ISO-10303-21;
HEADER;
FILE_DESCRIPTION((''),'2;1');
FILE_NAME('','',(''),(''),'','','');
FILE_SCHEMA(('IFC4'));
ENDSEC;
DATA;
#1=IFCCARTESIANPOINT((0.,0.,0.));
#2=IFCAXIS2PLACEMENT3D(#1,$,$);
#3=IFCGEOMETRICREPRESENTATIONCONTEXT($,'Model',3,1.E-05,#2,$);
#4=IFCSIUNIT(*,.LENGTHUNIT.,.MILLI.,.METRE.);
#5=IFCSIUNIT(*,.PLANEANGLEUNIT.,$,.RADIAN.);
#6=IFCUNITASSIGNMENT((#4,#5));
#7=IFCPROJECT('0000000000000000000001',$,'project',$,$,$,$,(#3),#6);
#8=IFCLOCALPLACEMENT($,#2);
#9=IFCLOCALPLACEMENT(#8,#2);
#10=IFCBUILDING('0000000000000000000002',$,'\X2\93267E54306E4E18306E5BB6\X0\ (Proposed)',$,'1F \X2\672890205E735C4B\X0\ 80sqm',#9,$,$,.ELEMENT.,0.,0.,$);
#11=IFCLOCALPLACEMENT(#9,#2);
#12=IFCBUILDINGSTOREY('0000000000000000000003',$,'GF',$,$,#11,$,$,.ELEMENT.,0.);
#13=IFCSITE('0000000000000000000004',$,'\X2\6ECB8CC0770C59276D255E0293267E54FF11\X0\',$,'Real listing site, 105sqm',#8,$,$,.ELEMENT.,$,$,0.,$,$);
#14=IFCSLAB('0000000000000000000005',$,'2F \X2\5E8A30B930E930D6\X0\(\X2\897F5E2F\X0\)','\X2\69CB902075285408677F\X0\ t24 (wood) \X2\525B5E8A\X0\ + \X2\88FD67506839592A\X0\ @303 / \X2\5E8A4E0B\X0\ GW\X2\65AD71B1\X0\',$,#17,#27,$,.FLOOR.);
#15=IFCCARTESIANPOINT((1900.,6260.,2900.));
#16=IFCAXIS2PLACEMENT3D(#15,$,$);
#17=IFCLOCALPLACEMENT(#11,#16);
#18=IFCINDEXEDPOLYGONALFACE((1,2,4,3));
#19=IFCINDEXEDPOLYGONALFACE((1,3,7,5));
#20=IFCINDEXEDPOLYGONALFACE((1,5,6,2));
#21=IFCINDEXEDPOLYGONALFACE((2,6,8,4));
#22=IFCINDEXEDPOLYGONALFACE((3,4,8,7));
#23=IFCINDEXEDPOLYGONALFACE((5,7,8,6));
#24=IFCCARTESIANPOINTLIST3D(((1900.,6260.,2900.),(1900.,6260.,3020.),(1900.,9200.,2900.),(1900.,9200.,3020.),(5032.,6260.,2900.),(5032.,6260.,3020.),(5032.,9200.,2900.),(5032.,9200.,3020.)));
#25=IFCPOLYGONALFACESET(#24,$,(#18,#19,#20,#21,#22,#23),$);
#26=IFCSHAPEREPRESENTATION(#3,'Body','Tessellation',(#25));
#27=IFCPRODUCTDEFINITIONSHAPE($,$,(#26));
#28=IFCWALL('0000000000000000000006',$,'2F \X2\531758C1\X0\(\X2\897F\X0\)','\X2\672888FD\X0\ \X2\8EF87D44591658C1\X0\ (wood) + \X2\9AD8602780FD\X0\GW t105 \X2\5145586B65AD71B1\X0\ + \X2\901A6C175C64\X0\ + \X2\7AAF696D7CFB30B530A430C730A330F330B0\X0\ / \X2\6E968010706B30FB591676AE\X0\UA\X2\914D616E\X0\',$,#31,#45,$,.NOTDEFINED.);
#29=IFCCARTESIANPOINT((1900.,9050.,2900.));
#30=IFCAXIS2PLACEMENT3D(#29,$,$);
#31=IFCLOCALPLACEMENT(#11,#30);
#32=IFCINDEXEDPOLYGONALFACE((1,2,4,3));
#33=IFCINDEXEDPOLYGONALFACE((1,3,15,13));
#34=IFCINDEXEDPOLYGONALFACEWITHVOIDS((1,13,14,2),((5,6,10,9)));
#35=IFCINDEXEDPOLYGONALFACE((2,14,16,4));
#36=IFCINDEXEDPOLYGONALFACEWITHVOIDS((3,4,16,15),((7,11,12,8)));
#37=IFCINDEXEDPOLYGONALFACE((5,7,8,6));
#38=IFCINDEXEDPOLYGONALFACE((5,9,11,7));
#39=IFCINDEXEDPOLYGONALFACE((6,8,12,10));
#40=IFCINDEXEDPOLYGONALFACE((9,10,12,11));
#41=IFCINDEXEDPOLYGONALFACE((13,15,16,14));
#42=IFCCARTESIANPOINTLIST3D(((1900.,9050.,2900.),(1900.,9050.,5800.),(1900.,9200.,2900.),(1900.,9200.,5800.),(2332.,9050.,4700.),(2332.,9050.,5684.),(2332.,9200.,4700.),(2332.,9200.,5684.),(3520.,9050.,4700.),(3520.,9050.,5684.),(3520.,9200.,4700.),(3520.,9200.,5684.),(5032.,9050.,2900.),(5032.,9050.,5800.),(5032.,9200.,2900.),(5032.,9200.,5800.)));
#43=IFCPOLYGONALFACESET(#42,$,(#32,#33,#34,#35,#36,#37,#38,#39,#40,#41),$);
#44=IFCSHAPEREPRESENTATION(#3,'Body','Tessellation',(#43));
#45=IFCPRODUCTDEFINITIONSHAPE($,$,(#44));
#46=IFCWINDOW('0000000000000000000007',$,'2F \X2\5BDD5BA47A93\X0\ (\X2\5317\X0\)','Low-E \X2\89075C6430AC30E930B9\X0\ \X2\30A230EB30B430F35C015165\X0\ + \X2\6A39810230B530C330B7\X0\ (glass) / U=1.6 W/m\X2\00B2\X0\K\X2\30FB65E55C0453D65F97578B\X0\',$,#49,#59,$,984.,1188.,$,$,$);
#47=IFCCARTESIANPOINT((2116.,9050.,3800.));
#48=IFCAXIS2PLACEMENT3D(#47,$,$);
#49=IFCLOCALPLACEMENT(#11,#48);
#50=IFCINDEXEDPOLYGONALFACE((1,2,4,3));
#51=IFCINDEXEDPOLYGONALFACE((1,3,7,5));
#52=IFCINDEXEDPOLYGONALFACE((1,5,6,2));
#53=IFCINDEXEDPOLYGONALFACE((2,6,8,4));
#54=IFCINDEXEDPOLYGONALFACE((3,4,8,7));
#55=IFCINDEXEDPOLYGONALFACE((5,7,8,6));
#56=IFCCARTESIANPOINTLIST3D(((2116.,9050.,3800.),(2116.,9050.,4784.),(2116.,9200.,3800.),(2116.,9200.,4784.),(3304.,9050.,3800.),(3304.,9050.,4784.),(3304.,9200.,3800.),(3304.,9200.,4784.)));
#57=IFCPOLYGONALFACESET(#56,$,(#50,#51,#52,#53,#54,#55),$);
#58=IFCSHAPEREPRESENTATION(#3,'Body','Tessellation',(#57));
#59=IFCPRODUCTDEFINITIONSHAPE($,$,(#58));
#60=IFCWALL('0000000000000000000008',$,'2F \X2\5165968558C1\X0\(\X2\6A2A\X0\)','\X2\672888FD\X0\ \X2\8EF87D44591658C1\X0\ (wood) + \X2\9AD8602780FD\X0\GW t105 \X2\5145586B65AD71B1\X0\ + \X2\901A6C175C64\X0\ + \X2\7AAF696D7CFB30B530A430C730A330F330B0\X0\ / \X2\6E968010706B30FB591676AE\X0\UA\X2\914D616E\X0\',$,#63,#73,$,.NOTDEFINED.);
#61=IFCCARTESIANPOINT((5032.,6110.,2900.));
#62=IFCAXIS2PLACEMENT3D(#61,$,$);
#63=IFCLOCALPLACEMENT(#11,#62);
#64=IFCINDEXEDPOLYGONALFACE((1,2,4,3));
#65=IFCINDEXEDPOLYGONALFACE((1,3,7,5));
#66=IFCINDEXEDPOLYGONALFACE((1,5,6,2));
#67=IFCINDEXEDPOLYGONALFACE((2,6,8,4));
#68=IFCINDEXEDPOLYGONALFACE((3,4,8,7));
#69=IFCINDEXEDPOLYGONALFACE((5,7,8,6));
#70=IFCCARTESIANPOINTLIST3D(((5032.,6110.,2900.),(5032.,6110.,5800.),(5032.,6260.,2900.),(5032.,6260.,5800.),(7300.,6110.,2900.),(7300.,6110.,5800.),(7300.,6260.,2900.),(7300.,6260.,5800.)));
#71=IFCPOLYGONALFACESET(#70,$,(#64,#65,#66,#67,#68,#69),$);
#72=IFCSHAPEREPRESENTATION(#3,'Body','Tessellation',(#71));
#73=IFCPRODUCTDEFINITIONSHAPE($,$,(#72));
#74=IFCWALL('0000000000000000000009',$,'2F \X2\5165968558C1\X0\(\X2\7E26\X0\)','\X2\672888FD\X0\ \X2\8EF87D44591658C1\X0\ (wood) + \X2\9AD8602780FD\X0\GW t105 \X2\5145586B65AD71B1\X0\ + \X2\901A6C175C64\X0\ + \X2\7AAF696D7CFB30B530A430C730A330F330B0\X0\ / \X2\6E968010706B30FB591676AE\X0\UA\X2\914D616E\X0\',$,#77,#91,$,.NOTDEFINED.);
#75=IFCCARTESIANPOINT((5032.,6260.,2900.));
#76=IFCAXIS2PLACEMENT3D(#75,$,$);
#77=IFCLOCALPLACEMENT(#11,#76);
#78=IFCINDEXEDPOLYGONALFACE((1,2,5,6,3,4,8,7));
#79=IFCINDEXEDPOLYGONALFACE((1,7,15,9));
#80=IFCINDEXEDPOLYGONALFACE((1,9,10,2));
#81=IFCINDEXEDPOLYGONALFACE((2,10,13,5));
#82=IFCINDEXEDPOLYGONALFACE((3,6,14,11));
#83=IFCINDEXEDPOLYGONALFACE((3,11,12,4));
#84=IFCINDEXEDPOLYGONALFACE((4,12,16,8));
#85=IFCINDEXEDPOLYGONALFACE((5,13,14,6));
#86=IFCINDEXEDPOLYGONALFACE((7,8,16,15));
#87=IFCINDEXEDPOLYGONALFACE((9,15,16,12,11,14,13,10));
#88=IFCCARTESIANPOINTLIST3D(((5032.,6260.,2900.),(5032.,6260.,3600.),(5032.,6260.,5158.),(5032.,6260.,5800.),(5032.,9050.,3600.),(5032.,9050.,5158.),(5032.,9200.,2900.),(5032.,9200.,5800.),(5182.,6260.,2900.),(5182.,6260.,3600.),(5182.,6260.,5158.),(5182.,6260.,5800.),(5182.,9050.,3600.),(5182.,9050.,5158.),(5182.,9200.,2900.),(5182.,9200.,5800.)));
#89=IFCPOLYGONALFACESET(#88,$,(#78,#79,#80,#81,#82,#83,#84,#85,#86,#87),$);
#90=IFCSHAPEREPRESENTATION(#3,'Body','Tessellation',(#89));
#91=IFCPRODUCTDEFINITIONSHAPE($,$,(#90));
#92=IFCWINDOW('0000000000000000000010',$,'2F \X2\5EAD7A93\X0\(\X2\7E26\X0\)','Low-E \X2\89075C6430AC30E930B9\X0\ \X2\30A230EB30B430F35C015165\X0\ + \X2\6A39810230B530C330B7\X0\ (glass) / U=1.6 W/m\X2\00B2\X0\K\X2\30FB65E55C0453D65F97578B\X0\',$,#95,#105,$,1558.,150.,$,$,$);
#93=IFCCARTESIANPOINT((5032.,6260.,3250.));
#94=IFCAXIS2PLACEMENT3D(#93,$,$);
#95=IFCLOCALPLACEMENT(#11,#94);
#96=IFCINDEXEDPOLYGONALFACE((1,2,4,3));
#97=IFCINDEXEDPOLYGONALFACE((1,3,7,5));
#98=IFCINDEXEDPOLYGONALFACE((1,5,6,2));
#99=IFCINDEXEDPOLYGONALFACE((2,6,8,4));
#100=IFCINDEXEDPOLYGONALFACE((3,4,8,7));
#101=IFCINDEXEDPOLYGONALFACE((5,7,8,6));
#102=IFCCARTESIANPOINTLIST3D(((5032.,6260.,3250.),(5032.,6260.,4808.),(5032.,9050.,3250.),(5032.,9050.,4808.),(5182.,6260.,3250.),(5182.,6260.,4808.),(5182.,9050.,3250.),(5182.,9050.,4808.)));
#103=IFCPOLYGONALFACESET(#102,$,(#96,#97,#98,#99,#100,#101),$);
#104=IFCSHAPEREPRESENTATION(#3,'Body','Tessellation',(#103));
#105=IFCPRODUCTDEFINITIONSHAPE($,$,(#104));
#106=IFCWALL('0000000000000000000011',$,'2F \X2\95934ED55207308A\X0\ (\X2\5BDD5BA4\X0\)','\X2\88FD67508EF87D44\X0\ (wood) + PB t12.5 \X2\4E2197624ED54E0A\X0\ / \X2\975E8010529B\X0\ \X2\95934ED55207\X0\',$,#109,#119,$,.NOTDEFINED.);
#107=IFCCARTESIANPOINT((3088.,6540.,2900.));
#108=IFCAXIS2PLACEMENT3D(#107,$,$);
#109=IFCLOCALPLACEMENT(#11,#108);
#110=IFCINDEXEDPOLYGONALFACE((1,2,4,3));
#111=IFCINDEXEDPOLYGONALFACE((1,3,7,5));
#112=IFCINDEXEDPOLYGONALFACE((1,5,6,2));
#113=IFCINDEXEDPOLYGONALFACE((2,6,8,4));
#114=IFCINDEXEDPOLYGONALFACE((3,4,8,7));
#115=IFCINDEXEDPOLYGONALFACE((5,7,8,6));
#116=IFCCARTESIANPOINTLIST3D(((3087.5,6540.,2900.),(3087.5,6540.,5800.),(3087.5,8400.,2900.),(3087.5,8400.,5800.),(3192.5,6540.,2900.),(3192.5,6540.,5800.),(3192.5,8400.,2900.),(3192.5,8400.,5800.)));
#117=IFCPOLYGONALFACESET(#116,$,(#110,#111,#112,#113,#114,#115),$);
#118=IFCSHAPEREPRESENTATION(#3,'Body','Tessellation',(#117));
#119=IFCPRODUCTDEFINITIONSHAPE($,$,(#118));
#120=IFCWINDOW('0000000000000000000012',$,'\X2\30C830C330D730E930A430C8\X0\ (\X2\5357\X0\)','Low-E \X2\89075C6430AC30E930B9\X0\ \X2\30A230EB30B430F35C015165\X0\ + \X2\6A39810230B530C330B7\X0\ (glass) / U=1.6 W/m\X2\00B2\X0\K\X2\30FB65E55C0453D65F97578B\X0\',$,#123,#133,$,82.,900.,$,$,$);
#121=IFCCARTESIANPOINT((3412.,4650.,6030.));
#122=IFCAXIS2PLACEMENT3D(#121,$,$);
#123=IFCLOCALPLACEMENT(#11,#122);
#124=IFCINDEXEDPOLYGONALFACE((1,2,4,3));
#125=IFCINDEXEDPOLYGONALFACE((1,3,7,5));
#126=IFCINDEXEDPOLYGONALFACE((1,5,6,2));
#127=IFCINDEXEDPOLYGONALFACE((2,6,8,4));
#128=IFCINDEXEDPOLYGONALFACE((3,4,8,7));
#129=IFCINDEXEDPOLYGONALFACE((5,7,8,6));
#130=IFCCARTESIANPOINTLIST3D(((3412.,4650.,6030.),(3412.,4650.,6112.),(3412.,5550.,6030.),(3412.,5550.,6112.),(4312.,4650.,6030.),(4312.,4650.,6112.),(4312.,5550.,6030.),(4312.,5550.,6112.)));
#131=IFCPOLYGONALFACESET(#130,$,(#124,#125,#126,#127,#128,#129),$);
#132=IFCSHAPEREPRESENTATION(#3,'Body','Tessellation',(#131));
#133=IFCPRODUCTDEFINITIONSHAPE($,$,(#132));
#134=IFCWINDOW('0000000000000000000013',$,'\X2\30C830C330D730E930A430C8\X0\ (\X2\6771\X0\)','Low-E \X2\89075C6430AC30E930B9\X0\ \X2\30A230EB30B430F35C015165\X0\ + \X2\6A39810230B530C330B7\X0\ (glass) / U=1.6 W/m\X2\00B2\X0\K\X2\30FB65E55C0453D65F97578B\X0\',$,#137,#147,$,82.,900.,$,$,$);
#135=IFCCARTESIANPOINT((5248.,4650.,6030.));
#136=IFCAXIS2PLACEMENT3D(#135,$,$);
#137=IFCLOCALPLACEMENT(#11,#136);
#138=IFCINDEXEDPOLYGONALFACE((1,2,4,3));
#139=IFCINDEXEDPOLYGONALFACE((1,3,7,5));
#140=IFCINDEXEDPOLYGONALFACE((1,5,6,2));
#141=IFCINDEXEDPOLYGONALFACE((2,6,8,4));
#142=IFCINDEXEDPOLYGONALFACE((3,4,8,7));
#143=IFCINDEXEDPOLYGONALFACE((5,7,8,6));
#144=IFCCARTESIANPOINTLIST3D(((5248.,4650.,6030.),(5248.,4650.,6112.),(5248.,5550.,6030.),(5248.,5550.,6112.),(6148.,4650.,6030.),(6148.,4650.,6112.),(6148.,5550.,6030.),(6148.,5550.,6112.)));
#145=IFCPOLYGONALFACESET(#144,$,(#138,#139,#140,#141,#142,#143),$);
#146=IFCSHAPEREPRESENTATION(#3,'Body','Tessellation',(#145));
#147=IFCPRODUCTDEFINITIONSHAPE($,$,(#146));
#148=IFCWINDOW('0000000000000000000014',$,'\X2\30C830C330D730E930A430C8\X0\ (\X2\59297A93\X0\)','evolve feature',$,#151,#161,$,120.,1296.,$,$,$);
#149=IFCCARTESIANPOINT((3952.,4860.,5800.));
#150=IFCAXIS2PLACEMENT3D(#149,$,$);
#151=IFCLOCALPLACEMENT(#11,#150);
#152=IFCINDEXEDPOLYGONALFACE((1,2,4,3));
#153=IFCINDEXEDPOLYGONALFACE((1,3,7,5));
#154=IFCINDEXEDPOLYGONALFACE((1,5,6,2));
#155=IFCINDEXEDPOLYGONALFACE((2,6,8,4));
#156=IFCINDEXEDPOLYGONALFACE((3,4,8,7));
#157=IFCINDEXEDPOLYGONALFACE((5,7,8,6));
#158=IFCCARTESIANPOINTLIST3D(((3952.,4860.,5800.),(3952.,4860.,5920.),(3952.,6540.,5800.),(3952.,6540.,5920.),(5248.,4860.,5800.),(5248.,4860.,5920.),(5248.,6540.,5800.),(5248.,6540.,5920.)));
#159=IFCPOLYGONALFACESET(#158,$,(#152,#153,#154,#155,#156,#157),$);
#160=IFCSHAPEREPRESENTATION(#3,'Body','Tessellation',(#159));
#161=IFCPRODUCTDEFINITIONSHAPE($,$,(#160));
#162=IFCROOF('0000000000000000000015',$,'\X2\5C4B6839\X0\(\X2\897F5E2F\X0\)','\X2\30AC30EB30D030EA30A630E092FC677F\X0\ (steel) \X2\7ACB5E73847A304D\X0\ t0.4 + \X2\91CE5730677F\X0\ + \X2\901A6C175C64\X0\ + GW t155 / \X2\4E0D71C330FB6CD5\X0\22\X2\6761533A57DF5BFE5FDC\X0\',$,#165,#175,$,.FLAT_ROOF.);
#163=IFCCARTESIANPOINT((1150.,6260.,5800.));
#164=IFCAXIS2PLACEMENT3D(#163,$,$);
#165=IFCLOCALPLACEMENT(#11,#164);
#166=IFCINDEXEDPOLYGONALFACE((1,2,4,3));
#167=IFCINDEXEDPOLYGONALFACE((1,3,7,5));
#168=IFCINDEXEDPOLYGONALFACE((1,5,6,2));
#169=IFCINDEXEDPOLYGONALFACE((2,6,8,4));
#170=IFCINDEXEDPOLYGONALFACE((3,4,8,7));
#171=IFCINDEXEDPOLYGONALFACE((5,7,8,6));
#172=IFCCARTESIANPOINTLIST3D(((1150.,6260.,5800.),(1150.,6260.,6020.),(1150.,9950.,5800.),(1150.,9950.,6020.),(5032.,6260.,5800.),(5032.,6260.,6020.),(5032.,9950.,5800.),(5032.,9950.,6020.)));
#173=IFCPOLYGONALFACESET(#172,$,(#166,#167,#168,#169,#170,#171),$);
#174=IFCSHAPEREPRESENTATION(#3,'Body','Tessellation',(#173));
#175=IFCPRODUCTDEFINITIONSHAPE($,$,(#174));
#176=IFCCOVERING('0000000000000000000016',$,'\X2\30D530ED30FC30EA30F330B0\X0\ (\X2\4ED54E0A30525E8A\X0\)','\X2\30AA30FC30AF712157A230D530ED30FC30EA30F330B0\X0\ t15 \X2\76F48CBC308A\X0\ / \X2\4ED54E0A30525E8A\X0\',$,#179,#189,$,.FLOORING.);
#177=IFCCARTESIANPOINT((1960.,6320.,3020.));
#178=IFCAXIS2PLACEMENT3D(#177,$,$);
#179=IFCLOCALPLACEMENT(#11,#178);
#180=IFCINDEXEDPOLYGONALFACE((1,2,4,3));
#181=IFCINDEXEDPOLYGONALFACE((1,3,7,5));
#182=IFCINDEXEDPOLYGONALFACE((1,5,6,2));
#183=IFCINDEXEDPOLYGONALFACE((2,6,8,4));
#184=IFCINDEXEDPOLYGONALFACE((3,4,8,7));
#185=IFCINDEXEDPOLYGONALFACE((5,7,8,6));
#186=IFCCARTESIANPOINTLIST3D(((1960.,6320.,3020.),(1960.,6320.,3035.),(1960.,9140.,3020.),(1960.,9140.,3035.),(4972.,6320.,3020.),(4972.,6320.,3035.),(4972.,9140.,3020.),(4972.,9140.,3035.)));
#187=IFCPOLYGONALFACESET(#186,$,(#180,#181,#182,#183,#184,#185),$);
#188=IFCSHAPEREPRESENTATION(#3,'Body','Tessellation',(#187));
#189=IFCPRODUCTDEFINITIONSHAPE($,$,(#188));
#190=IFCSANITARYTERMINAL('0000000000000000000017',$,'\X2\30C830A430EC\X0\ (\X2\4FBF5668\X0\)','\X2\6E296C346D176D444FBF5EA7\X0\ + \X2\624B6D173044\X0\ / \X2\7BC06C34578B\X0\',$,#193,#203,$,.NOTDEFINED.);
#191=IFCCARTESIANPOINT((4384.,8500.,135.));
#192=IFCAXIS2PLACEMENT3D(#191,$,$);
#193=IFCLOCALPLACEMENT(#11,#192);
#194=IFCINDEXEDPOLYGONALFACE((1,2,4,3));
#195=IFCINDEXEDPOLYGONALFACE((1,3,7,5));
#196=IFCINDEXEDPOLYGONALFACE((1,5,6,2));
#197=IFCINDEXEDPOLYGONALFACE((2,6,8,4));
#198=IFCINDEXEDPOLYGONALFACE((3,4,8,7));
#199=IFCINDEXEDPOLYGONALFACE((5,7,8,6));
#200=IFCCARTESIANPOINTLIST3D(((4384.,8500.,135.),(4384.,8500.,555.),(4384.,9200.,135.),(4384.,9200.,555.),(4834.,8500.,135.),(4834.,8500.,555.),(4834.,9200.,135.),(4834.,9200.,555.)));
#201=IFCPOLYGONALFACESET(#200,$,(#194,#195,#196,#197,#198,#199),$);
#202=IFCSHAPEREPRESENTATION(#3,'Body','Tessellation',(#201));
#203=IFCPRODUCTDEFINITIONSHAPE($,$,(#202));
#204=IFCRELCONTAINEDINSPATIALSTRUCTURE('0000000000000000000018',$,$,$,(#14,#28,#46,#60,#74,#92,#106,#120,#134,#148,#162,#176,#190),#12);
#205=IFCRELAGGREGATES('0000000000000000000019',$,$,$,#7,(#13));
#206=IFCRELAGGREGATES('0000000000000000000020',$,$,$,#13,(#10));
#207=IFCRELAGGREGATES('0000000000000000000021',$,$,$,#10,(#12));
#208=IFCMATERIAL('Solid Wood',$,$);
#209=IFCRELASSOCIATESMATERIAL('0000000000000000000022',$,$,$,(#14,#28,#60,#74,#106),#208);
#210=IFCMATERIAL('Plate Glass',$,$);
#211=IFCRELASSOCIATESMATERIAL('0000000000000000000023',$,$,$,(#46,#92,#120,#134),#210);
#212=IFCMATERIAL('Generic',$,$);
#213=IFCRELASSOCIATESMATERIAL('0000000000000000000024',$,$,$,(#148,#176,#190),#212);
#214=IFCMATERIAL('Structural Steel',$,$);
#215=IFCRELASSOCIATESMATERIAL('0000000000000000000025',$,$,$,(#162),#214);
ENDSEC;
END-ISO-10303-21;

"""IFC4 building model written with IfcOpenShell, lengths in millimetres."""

from ifc_helpers import new_model, si_unit, frame, frame_2d, origin, place, context, project, spatial, rectangle, extrude, material, element, fill, save


model = new_model("IFC4")

# Units and contexts
model_context = context("Model", 3, precision=1e-05, world=origin())
ifc_project = project(units=[si_unit("LENGTHUNIT", "METRE", prefix="MILLI"), si_unit("PLANEANGLEUNIT", "RADIAN")], contexts=[model_context])

# Site, building, storey
site_placement = place(None, origin())
site = spatial("IfcSite", under=ifc_project, at=site_placement, Name="滋賀県大津市錦織１", ObjectType="Real listing site, 105sqm", CompositionType="ELEMENT", RefElevation=0.0)
building_placement = place(site_placement, origin())
building = spatial("IfcBuilding", under=site, at=building_placement, Name="錦織の丘の家 (Proposed)", ObjectType="1F 木造平屋 80sqm", CompositionType="ELEMENT", ElevationOfRefHeight=0.0, ElevationOfTerrain=0.0)
storey_placement = place(building_placement, origin())
storey = spatial("IfcBuildingStorey", under=building, at=storey_placement, Name="GF", CompositionType="ELEMENT", Elevation=0.0)

# Slab
ifc_material_1 = material(Name="Solid Wood")
slab_placement = place(storey_placement, frame((1900.0, 6260.0, 2900.0)))
element("IfcSlab", 1, at=slab_placement, inside=storey, material=ifc_material_1, Name="2F 床スラブ(西帯)", Description="構造用合板 t24 (wood) 剛床 + 製材根太 @303 / 床下 GW断熱", PredefinedType="FLOOR", context=model_context, shape_type="SweptSolid", body=[
    extrude(rectangle(XDim=3132.0, YDim=2940.0, at=frame_2d((1566.0, 1470.0))), frame((1900.0, 6260.0, 2900.0)), (0.0, 0.0, 1.0), 120.0),
])

# Wall, opening, window
wall_1_placement = place(storey_placement, frame((1900.0, 9050.0, 2900.0)))
wall_1 = element("IfcWall", 2, at=wall_1_placement, inside=storey, material=ifc_material_1, Name="2F 北壁(西)", Description="木製 軸組外壁 (wood) + 高性能GW t105 充填断熱 + 通気層 + 窯業系サイディング / 準耐火・外皮UA配慮", PredefinedType="NOTDEFINED", context=model_context, shape_type="SweptSolid", body=[
    extrude(rectangle(XDim=3132.0, YDim=150.0, at=frame_2d((1566.0, 75.0))), frame((1900.0, 9050.0, 2900.0)), (0.0, 0.0, 1.0), 2900.0),
])
opening_1_placement = place(storey_placement, frame((2116.0, 9050.0, 3800.0)))
opening_1 = element("IfcOpeningElement", 3, at=opening_1_placement, cuts=wall_1, PredefinedType="NOTDEFINED", context=model_context, shape_type="SweptSolid", body=[
    extrude(rectangle(XDim=1188.0, YDim=150.0, at=frame_2d((594.0, 75.0))), frame((2116.0, 9050.0, 3800.0)), (0.0, 0.0, 1.0), 984.0),
])
ifc_material_2 = material(Name="Plate Glass")
window_1_placement = place(storey_placement, frame((2116.0, 9050.0, 3800.0)))
window_1 = element("IfcWindow", 4, at=window_1_placement, inside=storey, material=ifc_material_2, Name="2F 寝室窓 (北)", Description="Low-E 複層ガラス アルゴン封入 + 樹脂サッシ (glass) / U=1.6 W/m²K・日射取得型", OverallHeight=984.0, OverallWidth=1188.0, context=model_context, shape_type="SweptSolid", body=[
    extrude(rectangle(XDim=1188.0, YDim=150.0, at=frame_2d((594.0, 75.0))), frame((2116.0, 9050.0, 3800.0)), (0.0, 0.0, 1.0), 984.0),
])
fill(opening_1, window_1)

# Wall
wall_2_placement = place(storey_placement, frame((5032.0, 6110.0, 2900.0)))
element("IfcWall", 5, at=wall_2_placement, inside=storey, material=ifc_material_1, Name="2F 入隅壁(横)", Description="木製 軸組外壁 (wood) + 高性能GW t105 充填断熱 + 通気層 + 窯業系サイディング / 準耐火・外皮UA配慮", PredefinedType="NOTDEFINED", context=model_context, shape_type="SweptSolid", body=[
    extrude(rectangle(XDim=2268.0, YDim=150.0, at=frame_2d((1134.0, 75.0))), frame((5032.0, 6110.0, 2900.0)), (0.0, 0.0, 1.0), 2900.0),
])

# Wall, opening, window
wall_3_placement = place(storey_placement, frame((5032.0, 6260.0, 2900.0)))
wall_3 = element("IfcWall", 6, at=wall_3_placement, inside=storey, material=ifc_material_1, Name="2F 入隅壁(縦)", Description="木製 軸組外壁 (wood) + 高性能GW t105 充填断熱 + 通気層 + 窯業系サイディング / 準耐火・外皮UA配慮", PredefinedType="NOTDEFINED", context=model_context, shape_type="SweptSolid", body=[
    extrude(rectangle(XDim=150.0, YDim=2940.0, at=frame_2d((75.0, 1470.0))), frame((5032.0, 6260.0, 2900.0)), (0.0, 0.0, 1.0), 2900.0),
])
opening_2_placement = place(storey_placement, frame((5032.0, 6260.0, 3250.0)))
opening_2 = element("IfcOpeningElement", 7, at=opening_2_placement, cuts=wall_3, PredefinedType="NOTDEFINED", context=model_context, shape_type="SweptSolid", body=[
    extrude(rectangle(XDim=150.0, YDim=2790.0, at=frame_2d((75.0, 1395.0))), frame((5032.0, 6260.0, 3250.0)), (0.0, 0.0, 1.0), 1558.0),
])
window_2_placement = place(storey_placement, frame((5032.0, 6260.0, 3250.0)))
window_2 = element("IfcWindow", 8, at=window_2_placement, inside=storey, material=ifc_material_2, Name="2F 庭窓(縦)", Description="Low-E 複層ガラス アルゴン封入 + 樹脂サッシ (glass) / U=1.6 W/m²K・日射取得型", OverallHeight=1558.0, OverallWidth=150.0, context=model_context, shape_type="SweptSolid", body=[
    extrude(rectangle(XDim=150.0, YDim=2790.0, at=frame_2d((75.0, 1395.0))), frame((5032.0, 6260.0, 3250.0)), (0.0, 0.0, 1.0), 1558.0),
])
fill(opening_2, window_2)

# Wall
wall_4_placement = place(storey_placement, frame((3088.0, 6540.0, 2900.0)))
element("IfcWall", 9, at=wall_4_placement, inside=storey, material=ifc_material_1, Name="2F 間仕切り (寝室)", Description="製材軸組 (wood) + PB t12.5 両面仕上 / 非耐力 間仕切", PredefinedType="NOTDEFINED", context=model_context, shape_type="SweptSolid", body=[
    extrude(rectangle(XDim=105.0, YDim=1860.0, at=frame_2d((52.0, 930.0))), frame((3088.0, 6540.0, 2900.0)), (0.0, 0.0, 1.0), 2900.0),
])

# Windows
window_3_placement = place(storey_placement, frame((3412.0, 4650.0, 6030.0)))
element("IfcWindow", 10, at=window_3_placement, inside=storey, material=ifc_material_2, Name="トップライト (南)", Description="Low-E 複層ガラス アルゴン封入 + 樹脂サッシ (glass) / U=1.6 W/m²K・日射取得型", OverallHeight=82.0, OverallWidth=900.0, context=model_context, shape_type="SweptSolid", body=[
    extrude(rectangle(XDim=900.0, YDim=900.0, at=frame_2d((450.0, 450.0))), frame((3412.0, 4650.0, 6030.0)), (0.0, 0.0, 1.0), 82.0),
])
window_4_placement = place(storey_placement, frame((5248.0, 4650.0, 6030.0)))
element("IfcWindow", 11, at=window_4_placement, inside=storey, material=ifc_material_2, Name="トップライト (東)", Description="Low-E 複層ガラス アルゴン封入 + 樹脂サッシ (glass) / U=1.6 W/m²K・日射取得型", OverallHeight=82.0, OverallWidth=900.0, context=model_context, shape_type="SweptSolid", body=[
    extrude(rectangle(XDim=900.0, YDim=900.0, at=frame_2d((450.0, 450.0))), frame((5248.0, 4650.0, 6030.0)), (0.0, 0.0, 1.0), 82.0),
])
ifc_material_3 = material(Name="Generic")
window_5_placement = place(storey_placement, frame((3952.0, 4860.0, 5800.0)))
element("IfcWindow", 12, at=window_5_placement, inside=storey, material=ifc_material_3, Name="トップライト (天窓)", Description="evolve feature", OverallHeight=120.0, OverallWidth=1296.0, context=model_context, shape_type="SweptSolid", body=[
    extrude(rectangle(XDim=1296.0, YDim=1680.0, at=frame_2d((648.0, 840.0))), frame((3952.0, 4860.0, 5800.0)), (0.0, 0.0, 1.0), 120.0),
])

# Roof
ifc_material_4 = material(Name="Structural Steel")
for number, where, name in (
    (13, (1150.0, 6260.0, 5800.0), "屋根(西帯)"),
):
    element("IfcRoof", number, at=place(storey_placement, frame(where)), inside=storey, material=ifc_material_4, Name=name, Description="ガルバリウム鋼板 (steel) 立平葺き t0.4 + 野地板 + 通気層 + GW t155 / 不燃・法22条区域対応", PredefinedType="FLAT_ROOF", context=model_context, shape_type="SweptSolid", body=[
        extrude(rectangle(XDim=3882.0, YDim=3690.0, at=frame_2d((1941.0, 1845.0))), frame((1150.0, 6260.0, 5800.0)), (0.0, 0.0, 1.0), 220.0),
    ])

# Covering
covering_placement = place(storey_placement, frame((1960.0, 6320.0, 3020.0)))
element("IfcCovering", 14, at=covering_placement, inside=storey, material=ifc_material_3, Name="フローリング (仕上げ床)", Description="オーク無垢フローリング t15 直貼り / 仕上げ床", PredefinedType="FLOORING", context=model_context, shape_type="SweptSolid", body=[
    extrude(rectangle(XDim=3012.0, YDim=2820.0, at=frame_2d((1506.0, 1410.0))), frame((1960.0, 6320.0, 3020.0)), (0.0, 0.0, 1.0), 15.0),
])

# Sanitary terminal
sanitary_terminal_placement = place(storey_placement, frame((4384.0, 8500.0, 135.0)))
element("IfcSanitaryTerminal", 15, at=sanitary_terminal_placement, inside=storey, material=ifc_material_3, Name="トイレ (便器)", Description="温水洗浄便座 + 手洗い / 節水型", PredefinedType="NOTDEFINED", context=model_context, shape_type="SweptSolid", body=[
    extrude(rectangle(XDim=450.0, YDim=700.0, at=frame_2d((225.0, 350.0))), frame((4384.0, 8500.0, 135.0)), (0.0, 0.0, 1.0), 420.0),
])

save(model, "model.ifc")
